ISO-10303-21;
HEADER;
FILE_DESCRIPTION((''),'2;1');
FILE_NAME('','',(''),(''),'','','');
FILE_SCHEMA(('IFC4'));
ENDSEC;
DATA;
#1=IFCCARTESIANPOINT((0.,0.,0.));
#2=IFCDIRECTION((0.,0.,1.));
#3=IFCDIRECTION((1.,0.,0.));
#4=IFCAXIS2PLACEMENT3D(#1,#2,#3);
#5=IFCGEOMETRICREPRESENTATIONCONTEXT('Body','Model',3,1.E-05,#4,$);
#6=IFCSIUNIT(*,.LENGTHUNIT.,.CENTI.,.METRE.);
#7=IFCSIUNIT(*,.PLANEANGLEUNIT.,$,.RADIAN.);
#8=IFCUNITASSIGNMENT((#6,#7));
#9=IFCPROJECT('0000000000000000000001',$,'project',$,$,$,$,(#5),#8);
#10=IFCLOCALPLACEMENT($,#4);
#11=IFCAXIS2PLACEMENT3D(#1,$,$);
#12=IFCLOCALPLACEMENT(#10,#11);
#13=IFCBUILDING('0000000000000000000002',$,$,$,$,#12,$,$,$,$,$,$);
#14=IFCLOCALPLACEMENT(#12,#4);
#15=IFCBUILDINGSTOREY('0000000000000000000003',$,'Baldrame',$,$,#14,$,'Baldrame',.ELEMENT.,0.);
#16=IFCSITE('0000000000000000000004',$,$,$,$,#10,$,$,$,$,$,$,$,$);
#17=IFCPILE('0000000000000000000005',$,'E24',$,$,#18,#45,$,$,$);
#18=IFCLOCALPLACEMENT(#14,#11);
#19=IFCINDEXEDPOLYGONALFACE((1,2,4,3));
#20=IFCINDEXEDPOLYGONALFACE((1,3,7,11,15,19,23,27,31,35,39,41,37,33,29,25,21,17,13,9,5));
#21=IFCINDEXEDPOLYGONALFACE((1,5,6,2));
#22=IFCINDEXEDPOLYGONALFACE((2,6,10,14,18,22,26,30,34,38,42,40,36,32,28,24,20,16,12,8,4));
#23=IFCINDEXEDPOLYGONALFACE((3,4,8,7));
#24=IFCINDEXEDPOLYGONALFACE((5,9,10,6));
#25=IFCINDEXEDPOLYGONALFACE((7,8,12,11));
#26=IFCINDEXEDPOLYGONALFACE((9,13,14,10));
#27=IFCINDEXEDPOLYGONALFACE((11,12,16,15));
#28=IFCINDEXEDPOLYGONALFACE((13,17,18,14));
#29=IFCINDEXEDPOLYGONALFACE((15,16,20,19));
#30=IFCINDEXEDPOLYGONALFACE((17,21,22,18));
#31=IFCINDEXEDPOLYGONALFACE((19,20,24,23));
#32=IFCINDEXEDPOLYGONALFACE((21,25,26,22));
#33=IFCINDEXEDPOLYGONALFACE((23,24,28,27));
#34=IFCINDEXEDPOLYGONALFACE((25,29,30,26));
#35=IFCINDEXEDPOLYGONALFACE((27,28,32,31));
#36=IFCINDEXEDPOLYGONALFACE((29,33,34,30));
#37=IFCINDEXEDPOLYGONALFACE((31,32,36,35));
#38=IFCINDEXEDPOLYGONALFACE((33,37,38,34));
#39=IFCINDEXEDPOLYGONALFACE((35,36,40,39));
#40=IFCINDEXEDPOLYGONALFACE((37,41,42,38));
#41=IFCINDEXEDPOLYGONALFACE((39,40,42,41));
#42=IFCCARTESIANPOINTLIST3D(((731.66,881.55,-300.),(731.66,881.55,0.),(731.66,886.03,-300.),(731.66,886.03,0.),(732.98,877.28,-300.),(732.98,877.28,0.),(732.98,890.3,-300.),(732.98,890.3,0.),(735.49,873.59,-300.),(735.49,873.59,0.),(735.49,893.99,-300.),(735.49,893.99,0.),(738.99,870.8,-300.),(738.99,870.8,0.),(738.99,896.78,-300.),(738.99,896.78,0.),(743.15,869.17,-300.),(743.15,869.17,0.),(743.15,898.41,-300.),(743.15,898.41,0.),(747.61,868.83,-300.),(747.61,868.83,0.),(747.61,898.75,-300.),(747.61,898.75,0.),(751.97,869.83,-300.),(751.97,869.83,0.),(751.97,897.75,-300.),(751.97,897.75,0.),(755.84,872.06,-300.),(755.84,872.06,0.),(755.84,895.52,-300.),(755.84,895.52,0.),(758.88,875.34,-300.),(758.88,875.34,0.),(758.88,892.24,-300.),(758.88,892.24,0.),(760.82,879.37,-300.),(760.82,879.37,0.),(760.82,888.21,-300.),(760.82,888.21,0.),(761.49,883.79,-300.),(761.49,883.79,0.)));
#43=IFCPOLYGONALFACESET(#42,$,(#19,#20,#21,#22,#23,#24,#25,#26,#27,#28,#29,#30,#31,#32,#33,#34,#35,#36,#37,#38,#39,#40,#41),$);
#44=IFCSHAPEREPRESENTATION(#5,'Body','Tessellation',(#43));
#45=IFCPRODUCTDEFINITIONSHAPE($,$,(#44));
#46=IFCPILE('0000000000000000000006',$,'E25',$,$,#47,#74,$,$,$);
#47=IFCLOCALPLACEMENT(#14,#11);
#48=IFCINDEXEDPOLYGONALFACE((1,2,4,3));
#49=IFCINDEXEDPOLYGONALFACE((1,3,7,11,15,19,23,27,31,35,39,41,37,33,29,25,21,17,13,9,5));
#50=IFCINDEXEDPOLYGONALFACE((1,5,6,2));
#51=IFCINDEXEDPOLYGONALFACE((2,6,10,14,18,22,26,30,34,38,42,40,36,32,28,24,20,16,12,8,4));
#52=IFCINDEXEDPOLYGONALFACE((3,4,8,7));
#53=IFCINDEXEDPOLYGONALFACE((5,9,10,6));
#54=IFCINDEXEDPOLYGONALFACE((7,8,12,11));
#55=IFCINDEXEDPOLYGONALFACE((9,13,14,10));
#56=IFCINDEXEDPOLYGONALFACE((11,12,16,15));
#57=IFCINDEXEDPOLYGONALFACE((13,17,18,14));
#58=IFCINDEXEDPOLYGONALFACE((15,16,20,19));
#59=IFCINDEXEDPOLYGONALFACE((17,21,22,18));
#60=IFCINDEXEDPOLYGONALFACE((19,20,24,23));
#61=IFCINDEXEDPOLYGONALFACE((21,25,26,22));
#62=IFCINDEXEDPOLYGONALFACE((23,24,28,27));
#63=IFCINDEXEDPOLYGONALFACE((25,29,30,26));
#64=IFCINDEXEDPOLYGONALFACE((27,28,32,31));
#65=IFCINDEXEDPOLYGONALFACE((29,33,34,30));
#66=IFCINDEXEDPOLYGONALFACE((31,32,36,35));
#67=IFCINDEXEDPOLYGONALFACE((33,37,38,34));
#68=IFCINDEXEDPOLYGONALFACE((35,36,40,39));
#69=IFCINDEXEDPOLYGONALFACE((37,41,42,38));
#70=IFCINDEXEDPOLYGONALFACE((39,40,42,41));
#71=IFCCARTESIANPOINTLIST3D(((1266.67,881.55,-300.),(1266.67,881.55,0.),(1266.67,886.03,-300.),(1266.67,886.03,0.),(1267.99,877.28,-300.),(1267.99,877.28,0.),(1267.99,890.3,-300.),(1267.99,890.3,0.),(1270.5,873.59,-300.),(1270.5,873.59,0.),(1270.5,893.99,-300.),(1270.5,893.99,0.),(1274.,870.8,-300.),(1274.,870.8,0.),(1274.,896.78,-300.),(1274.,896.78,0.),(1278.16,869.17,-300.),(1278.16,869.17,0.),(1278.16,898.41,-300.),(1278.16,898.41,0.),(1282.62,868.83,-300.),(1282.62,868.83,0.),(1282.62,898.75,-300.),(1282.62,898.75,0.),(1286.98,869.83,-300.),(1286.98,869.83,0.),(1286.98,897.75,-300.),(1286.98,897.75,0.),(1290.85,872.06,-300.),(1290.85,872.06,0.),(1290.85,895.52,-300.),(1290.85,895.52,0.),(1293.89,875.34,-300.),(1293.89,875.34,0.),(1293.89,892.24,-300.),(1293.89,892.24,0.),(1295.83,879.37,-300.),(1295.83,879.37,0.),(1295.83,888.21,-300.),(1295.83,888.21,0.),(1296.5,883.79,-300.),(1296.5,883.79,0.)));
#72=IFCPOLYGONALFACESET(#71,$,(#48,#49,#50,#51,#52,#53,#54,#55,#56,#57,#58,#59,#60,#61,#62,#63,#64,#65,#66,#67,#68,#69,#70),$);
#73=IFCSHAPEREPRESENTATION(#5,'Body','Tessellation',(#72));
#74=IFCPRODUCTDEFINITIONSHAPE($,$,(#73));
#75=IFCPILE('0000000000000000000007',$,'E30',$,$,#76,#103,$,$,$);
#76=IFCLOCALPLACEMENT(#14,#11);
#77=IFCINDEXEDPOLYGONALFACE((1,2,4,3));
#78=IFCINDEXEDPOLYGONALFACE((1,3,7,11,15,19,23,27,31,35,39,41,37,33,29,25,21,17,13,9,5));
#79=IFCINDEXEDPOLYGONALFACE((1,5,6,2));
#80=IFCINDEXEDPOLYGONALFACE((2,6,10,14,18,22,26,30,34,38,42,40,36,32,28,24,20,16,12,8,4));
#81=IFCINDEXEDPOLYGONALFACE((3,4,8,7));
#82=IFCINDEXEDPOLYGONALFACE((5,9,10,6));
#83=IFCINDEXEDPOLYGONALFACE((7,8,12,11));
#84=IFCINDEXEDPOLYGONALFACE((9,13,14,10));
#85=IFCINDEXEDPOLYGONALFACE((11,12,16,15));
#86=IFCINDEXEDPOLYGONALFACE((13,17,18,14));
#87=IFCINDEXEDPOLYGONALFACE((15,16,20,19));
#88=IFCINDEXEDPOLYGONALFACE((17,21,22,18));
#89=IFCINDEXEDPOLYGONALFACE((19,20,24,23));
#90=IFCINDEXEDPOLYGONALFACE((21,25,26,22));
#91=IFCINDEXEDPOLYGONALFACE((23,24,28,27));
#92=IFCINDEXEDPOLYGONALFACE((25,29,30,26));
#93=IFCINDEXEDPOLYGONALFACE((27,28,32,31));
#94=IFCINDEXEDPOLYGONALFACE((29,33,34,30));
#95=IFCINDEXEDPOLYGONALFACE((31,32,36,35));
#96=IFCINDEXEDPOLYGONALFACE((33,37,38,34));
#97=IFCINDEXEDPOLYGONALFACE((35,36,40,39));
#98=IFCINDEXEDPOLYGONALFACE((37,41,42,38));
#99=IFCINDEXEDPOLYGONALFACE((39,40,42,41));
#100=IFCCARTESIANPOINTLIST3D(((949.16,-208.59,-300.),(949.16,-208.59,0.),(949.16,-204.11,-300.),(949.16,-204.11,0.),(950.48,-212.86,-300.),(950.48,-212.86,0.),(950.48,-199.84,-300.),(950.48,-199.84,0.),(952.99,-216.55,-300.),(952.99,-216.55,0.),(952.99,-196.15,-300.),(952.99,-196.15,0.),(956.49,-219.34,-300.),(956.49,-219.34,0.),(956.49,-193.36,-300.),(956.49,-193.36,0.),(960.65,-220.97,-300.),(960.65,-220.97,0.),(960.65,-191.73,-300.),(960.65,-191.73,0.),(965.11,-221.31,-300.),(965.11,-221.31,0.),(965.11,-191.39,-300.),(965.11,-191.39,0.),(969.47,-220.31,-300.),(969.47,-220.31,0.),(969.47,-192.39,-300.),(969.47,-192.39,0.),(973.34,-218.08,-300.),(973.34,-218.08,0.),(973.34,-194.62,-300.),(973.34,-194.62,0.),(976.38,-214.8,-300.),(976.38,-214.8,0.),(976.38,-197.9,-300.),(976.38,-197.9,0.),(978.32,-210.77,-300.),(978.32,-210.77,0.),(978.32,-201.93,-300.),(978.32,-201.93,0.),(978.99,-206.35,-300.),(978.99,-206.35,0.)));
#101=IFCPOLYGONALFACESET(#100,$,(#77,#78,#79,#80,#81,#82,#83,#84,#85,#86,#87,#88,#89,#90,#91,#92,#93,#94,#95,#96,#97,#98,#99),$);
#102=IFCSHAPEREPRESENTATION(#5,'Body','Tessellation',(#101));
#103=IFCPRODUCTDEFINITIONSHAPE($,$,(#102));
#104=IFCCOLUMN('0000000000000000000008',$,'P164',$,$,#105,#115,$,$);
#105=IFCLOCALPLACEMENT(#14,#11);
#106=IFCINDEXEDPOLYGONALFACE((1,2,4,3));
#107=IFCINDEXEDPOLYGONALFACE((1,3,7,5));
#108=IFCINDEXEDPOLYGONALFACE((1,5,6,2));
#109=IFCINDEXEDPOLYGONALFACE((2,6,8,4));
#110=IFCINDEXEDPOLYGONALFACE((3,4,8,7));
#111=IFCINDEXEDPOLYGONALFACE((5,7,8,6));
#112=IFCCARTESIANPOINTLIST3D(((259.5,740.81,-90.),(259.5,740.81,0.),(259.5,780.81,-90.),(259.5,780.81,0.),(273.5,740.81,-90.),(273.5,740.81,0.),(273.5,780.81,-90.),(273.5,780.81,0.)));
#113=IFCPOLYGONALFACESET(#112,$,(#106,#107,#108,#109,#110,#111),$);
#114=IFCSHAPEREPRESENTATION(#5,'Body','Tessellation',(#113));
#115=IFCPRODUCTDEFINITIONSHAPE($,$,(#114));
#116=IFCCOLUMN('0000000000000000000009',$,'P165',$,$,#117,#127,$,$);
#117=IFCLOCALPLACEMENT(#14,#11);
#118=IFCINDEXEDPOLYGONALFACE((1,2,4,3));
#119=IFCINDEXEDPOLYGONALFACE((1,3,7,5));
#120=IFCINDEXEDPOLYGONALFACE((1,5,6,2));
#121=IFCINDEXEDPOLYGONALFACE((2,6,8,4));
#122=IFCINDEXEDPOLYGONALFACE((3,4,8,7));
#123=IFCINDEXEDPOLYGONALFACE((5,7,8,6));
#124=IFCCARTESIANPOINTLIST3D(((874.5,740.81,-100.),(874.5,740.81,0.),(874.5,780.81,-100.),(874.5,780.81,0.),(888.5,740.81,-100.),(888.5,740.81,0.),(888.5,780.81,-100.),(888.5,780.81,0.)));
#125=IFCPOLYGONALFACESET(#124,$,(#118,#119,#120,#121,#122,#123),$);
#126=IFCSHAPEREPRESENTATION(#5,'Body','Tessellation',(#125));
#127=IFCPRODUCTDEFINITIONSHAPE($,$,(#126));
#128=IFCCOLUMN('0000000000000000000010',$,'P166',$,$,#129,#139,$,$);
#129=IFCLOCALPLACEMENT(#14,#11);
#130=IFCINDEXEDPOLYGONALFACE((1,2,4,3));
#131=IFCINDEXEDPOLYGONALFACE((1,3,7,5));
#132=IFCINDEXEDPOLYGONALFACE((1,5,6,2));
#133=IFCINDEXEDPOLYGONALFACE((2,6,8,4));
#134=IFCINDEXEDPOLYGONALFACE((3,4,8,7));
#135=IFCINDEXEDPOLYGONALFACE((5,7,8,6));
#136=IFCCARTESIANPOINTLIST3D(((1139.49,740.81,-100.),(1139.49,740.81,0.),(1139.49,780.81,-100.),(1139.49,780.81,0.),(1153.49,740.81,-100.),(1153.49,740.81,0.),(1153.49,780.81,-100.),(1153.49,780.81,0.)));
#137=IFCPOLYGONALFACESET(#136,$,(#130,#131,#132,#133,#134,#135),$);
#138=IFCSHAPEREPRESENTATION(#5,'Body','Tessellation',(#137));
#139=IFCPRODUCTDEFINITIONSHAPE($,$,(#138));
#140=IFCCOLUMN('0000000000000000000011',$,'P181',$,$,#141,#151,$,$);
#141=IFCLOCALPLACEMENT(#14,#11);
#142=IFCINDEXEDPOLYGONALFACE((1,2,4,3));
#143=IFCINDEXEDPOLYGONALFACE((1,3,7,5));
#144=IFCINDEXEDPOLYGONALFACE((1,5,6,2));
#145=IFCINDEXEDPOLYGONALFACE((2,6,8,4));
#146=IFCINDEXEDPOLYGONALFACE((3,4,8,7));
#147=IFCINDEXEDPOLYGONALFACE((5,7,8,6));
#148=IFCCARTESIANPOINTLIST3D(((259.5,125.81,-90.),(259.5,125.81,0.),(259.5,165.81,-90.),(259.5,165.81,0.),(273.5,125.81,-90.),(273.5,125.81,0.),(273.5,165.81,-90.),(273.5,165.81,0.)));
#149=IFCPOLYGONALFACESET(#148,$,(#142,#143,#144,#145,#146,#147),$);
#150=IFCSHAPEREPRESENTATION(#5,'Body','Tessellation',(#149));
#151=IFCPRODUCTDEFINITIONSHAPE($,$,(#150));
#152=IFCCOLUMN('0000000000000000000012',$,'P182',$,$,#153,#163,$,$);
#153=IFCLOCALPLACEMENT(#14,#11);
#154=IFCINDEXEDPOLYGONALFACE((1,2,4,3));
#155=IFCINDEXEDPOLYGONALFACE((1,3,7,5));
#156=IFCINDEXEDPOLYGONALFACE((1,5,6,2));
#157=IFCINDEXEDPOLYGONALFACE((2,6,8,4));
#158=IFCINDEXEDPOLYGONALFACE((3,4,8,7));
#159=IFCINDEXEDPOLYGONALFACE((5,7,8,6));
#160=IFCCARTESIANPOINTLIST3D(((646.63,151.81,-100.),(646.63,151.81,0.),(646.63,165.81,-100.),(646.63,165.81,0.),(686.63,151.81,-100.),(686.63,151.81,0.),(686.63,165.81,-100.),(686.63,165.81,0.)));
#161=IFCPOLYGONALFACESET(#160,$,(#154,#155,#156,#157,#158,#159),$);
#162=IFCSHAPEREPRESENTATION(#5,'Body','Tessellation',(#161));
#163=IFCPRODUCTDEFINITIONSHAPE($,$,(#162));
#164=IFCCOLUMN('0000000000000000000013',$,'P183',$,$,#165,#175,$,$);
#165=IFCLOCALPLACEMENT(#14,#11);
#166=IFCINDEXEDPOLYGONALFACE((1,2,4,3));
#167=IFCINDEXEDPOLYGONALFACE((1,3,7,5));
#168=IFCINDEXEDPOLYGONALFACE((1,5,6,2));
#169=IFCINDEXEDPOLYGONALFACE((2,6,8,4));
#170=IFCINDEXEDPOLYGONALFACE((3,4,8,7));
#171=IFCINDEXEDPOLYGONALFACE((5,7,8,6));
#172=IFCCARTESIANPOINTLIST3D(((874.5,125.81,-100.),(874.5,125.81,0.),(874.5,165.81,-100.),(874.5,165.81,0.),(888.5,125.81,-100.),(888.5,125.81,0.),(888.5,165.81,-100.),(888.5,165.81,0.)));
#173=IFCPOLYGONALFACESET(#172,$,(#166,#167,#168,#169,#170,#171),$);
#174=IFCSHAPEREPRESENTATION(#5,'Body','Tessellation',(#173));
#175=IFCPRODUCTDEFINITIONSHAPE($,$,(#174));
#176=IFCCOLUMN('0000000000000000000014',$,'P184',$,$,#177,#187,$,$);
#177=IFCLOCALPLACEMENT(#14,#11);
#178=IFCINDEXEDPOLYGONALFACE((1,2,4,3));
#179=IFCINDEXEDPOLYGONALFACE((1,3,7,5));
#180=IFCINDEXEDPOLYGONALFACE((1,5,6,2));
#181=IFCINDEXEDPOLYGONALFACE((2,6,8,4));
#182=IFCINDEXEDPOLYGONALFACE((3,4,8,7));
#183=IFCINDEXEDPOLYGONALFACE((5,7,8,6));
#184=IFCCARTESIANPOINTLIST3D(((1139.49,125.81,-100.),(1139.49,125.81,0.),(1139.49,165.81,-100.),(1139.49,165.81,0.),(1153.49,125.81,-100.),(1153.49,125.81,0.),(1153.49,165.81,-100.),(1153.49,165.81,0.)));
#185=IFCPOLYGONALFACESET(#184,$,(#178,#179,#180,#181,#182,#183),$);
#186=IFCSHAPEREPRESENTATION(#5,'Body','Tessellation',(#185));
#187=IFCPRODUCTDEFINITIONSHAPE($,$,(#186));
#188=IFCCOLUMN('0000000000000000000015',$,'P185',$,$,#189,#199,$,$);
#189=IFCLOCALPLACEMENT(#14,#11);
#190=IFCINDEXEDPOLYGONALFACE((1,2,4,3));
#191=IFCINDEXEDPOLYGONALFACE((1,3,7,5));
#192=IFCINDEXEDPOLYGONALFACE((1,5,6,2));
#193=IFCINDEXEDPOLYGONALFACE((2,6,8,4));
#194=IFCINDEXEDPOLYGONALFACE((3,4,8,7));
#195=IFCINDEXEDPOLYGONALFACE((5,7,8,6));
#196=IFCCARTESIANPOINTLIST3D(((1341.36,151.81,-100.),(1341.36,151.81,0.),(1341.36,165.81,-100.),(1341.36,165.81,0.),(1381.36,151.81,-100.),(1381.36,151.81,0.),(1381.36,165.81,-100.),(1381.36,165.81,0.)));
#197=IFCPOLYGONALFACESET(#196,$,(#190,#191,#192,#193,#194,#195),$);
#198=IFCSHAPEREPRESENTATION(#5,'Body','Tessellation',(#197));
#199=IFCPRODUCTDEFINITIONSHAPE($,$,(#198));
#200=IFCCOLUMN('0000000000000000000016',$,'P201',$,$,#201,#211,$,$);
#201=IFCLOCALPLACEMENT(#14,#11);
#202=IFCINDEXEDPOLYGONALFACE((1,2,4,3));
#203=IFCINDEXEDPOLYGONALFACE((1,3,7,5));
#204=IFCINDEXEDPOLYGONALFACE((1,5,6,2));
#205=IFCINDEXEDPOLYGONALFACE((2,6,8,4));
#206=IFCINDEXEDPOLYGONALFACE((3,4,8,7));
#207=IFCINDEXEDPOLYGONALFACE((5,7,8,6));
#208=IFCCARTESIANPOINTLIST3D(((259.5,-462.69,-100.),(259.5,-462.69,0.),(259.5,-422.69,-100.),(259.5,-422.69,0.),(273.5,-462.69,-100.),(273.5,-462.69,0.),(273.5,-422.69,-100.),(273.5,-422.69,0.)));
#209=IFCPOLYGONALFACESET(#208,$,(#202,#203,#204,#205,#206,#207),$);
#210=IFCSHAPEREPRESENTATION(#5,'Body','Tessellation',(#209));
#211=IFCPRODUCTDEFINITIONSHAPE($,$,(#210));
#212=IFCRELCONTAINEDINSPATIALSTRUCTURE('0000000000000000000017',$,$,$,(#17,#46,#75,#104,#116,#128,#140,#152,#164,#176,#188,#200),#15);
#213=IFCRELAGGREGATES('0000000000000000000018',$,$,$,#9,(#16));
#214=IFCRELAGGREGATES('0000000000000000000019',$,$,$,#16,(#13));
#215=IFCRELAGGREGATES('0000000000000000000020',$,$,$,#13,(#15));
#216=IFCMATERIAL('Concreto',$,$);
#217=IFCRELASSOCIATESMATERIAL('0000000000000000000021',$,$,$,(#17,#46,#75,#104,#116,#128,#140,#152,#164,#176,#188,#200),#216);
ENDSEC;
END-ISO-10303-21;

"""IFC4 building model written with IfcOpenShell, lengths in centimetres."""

from ifc_helpers import new_model, si_unit, frame, origin, origin_with_axes, origin_2d_with_axis, place, context, project, spatial, rectangle, circle, extrude, material, element, save


model = new_model("IFC4")

# Units and contexts
model_context = context("Model", 3, precision=1e-05, world=origin_with_axes(), identifier="Body")
ifc_project = project(units=[si_unit("LENGTHUNIT", "METRE", prefix="CENTI"), si_unit("PLANEANGLEUNIT", "RADIAN")], contexts=[model_context])

# Site, building, storey
site_placement = place(None, origin_with_axes())
site = spatial("IfcSite", under=ifc_project, at=site_placement)
building_placement = place(site_placement, origin())
building = spatial("IfcBuilding", under=site, at=building_placement)
storey_placement = place(building_placement, origin_with_axes())
storey = spatial("IfcBuildingStorey", under=building, at=storey_placement, Name="Baldrame", LongName="Baldrame", CompositionType="ELEMENT", Elevation=0.0)

# Piles
ifc_material = material(Name="Concreto")
for number, where, z_axis, x_axis, name in (
    (1, (746.49, 883.79, 0.0), (0.0, 0.0, 1.0), (1.0, 0.0, 0.0), "E24"),
    (2, (1281.5, 883.79, 0.0), (0.0, 0.0, 1.0), (1.0, 0.0, 0.0), "E25"),
    (3, (963.99, -206.35, 0.0), (0.0, 0.0, 1.0), (1.0, 0.0, 0.0), "E30"),
):
    element("IfcPile", number, at=place(storey_placement, frame(where, z_axis=z_axis, x_axis=x_axis)), inside=storey, material=ifc_material, Name=name, context=model_context, shape_type="SolidModel", body=[
        extrude(circle(Radius=15.0, at=origin_2d_with_axis()), frame((0.0, 0.0, -300.0), z_axis=(0.0, 0.0, 1.0), x_axis=(1.0, 0.0, 0.0)), (0.0, 0.0, 1.0), 300.0),
    ])

# Columns
column_1_placement = place(storey_placement, frame((266.5, 760.81, 0.0), z_axis=(0.0, 0.0, 1.0), x_axis=(1.0, 0.0, 0.0)))
element("IfcColumn", 4, at=column_1_placement, inside=storey, material=ifc_material, Name="P164", context=model_context, shape_type="SolidModel", body=[
    extrude(rectangle(XDim=14.0, YDim=40.0, at=origin_2d_with_axis()), frame((0.0, 0.0, -90.0), z_axis=(0.0, 0.0, 1.0), x_axis=(1.0, 0.0, 0.0)), (0.0, 0.0, 1.0), 90.0),
])
for number, where, z_axis, x_axis, name in (
    (5, (881.5, 760.81, 0.0), (0.0, 0.0, 1.0), (1.0, 0.0, 0.0), "P165"),
    (6, (1146.49, 760.81, 0.0), (0.0, 0.0, 1.0), (1.0, 0.0, 0.0), "P166"),
):
    element("IfcColumn", number, at=place(storey_placement, frame(where, z_axis=z_axis, x_axis=x_axis)), inside=storey, material=ifc_material, Name=name, context=model_context, shape_type="SolidModel", body=[
        extrude(rectangle(XDim=14.0, YDim=40.0, at=origin_2d_with_axis()), frame((0.0, 0.0, -100.0), z_axis=(0.0, 0.0, 1.0), x_axis=(1.0, 0.0, 0.0)), (0.0, 0.0, 1.0), 100.0),
    ])
column_2_placement = place(storey_placement, frame((266.5, 145.81, 0.0), z_axis=(0.0, 0.0, 1.0), x_axis=(1.0, 0.0, 0.0)))
element("IfcColumn", 7, at=column_2_placement, inside=storey, material=ifc_material, Name="P181", context=model_context, shape_type="SolidModel", body=[
    extrude(rectangle(XDim=14.0, YDim=40.0, at=origin_2d_with_axis()), frame((0.0, 0.0, -90.0), z_axis=(0.0, 0.0, 1.0), x_axis=(1.0, 0.0, 0.0)), (0.0, 0.0, 1.0), 90.0),
])
column_3_placement = place(storey_placement, frame((666.63, 158.81, 0.0), z_axis=(0.0, 0.0, 1.0), x_axis=(1.0, 0.0, 0.0)))
element("IfcColumn", 8, at=column_3_placement, inside=storey, material=ifc_material, Name="P182", context=model_context, shape_type="SolidModel", body=[
    extrude(rectangle(XDim=14.0, YDim=40.0, at=origin_2d_with_axis()), frame((0.0, 0.0, -100.0), z_axis=(0.0, 0.0, 1.0), x_axis=(0.0, -1.0, 0.0)), (0.0, 0.0, 1.0), 100.0),
])
for number, where, z_axis, x_axis, name in (
    (9, (881.5, 145.81, 0.0), (0.0, 0.0, 1.0), (1.0, 0.0, 0.0), "P183"),
    (10, (1146.49, 145.81, 0.0), (0.0, 0.0, 1.0), (1.0, 0.0, 0.0), "P184"),
):
    element("IfcColumn", number, at=place(storey_placement, frame(where, z_axis=z_axis, x_axis=x_axis)), inside=storey, material=ifc_material, Name=name, context=model_context, shape_type="SolidModel", body=[
        extrude(rectangle(XDim=14.0, YDim=40.0, at=origin_2d_with_axis()), frame((0.0, 0.0, -100.0), z_axis=(0.0, 0.0, 1.0), x_axis=(1.0, 0.0, 0.0)), (0.0, 0.0, 1.0), 100.0),
    ])
column_4_placement = place(storey_placement, frame((1361.36, 158.81, 0.0), z_axis=(0.0, 0.0, 1.0), x_axis=(1.0, 0.0, 0.0)))
element("IfcColumn", 11, at=column_4_placement, inside=storey, material=ifc_material, Name="P185", context=model_context, shape_type="SolidModel", body=[
    extrude(rectangle(XDim=14.0, YDim=40.0, at=origin_2d_with_axis()), frame((0.0, 0.0, -100.0), z_axis=(0.0, 0.0, 1.0), x_axis=(0.0, 1.0, 0.0)), (0.0, 0.0, 1.0), 100.0),
])
column_5_placement = place(storey_placement, frame((266.5, -442.69, 0.0), z_axis=(0.0, 0.0, 1.0), x_axis=(1.0, 0.0, 0.0)))
element("IfcColumn", 12, at=column_5_placement, inside=storey, material=ifc_material, Name="P201", context=model_context, shape_type="SolidModel", body=[
    extrude(rectangle(XDim=14.0, YDim=40.0, at=origin_2d_with_axis()), frame((0.0, 0.0, -100.0), z_axis=(0.0, 0.0, 1.0), x_axis=(1.0, 0.0, 0.0)), (0.0, 0.0, 1.0), 100.0),
])

save(model, "model.ifc")
